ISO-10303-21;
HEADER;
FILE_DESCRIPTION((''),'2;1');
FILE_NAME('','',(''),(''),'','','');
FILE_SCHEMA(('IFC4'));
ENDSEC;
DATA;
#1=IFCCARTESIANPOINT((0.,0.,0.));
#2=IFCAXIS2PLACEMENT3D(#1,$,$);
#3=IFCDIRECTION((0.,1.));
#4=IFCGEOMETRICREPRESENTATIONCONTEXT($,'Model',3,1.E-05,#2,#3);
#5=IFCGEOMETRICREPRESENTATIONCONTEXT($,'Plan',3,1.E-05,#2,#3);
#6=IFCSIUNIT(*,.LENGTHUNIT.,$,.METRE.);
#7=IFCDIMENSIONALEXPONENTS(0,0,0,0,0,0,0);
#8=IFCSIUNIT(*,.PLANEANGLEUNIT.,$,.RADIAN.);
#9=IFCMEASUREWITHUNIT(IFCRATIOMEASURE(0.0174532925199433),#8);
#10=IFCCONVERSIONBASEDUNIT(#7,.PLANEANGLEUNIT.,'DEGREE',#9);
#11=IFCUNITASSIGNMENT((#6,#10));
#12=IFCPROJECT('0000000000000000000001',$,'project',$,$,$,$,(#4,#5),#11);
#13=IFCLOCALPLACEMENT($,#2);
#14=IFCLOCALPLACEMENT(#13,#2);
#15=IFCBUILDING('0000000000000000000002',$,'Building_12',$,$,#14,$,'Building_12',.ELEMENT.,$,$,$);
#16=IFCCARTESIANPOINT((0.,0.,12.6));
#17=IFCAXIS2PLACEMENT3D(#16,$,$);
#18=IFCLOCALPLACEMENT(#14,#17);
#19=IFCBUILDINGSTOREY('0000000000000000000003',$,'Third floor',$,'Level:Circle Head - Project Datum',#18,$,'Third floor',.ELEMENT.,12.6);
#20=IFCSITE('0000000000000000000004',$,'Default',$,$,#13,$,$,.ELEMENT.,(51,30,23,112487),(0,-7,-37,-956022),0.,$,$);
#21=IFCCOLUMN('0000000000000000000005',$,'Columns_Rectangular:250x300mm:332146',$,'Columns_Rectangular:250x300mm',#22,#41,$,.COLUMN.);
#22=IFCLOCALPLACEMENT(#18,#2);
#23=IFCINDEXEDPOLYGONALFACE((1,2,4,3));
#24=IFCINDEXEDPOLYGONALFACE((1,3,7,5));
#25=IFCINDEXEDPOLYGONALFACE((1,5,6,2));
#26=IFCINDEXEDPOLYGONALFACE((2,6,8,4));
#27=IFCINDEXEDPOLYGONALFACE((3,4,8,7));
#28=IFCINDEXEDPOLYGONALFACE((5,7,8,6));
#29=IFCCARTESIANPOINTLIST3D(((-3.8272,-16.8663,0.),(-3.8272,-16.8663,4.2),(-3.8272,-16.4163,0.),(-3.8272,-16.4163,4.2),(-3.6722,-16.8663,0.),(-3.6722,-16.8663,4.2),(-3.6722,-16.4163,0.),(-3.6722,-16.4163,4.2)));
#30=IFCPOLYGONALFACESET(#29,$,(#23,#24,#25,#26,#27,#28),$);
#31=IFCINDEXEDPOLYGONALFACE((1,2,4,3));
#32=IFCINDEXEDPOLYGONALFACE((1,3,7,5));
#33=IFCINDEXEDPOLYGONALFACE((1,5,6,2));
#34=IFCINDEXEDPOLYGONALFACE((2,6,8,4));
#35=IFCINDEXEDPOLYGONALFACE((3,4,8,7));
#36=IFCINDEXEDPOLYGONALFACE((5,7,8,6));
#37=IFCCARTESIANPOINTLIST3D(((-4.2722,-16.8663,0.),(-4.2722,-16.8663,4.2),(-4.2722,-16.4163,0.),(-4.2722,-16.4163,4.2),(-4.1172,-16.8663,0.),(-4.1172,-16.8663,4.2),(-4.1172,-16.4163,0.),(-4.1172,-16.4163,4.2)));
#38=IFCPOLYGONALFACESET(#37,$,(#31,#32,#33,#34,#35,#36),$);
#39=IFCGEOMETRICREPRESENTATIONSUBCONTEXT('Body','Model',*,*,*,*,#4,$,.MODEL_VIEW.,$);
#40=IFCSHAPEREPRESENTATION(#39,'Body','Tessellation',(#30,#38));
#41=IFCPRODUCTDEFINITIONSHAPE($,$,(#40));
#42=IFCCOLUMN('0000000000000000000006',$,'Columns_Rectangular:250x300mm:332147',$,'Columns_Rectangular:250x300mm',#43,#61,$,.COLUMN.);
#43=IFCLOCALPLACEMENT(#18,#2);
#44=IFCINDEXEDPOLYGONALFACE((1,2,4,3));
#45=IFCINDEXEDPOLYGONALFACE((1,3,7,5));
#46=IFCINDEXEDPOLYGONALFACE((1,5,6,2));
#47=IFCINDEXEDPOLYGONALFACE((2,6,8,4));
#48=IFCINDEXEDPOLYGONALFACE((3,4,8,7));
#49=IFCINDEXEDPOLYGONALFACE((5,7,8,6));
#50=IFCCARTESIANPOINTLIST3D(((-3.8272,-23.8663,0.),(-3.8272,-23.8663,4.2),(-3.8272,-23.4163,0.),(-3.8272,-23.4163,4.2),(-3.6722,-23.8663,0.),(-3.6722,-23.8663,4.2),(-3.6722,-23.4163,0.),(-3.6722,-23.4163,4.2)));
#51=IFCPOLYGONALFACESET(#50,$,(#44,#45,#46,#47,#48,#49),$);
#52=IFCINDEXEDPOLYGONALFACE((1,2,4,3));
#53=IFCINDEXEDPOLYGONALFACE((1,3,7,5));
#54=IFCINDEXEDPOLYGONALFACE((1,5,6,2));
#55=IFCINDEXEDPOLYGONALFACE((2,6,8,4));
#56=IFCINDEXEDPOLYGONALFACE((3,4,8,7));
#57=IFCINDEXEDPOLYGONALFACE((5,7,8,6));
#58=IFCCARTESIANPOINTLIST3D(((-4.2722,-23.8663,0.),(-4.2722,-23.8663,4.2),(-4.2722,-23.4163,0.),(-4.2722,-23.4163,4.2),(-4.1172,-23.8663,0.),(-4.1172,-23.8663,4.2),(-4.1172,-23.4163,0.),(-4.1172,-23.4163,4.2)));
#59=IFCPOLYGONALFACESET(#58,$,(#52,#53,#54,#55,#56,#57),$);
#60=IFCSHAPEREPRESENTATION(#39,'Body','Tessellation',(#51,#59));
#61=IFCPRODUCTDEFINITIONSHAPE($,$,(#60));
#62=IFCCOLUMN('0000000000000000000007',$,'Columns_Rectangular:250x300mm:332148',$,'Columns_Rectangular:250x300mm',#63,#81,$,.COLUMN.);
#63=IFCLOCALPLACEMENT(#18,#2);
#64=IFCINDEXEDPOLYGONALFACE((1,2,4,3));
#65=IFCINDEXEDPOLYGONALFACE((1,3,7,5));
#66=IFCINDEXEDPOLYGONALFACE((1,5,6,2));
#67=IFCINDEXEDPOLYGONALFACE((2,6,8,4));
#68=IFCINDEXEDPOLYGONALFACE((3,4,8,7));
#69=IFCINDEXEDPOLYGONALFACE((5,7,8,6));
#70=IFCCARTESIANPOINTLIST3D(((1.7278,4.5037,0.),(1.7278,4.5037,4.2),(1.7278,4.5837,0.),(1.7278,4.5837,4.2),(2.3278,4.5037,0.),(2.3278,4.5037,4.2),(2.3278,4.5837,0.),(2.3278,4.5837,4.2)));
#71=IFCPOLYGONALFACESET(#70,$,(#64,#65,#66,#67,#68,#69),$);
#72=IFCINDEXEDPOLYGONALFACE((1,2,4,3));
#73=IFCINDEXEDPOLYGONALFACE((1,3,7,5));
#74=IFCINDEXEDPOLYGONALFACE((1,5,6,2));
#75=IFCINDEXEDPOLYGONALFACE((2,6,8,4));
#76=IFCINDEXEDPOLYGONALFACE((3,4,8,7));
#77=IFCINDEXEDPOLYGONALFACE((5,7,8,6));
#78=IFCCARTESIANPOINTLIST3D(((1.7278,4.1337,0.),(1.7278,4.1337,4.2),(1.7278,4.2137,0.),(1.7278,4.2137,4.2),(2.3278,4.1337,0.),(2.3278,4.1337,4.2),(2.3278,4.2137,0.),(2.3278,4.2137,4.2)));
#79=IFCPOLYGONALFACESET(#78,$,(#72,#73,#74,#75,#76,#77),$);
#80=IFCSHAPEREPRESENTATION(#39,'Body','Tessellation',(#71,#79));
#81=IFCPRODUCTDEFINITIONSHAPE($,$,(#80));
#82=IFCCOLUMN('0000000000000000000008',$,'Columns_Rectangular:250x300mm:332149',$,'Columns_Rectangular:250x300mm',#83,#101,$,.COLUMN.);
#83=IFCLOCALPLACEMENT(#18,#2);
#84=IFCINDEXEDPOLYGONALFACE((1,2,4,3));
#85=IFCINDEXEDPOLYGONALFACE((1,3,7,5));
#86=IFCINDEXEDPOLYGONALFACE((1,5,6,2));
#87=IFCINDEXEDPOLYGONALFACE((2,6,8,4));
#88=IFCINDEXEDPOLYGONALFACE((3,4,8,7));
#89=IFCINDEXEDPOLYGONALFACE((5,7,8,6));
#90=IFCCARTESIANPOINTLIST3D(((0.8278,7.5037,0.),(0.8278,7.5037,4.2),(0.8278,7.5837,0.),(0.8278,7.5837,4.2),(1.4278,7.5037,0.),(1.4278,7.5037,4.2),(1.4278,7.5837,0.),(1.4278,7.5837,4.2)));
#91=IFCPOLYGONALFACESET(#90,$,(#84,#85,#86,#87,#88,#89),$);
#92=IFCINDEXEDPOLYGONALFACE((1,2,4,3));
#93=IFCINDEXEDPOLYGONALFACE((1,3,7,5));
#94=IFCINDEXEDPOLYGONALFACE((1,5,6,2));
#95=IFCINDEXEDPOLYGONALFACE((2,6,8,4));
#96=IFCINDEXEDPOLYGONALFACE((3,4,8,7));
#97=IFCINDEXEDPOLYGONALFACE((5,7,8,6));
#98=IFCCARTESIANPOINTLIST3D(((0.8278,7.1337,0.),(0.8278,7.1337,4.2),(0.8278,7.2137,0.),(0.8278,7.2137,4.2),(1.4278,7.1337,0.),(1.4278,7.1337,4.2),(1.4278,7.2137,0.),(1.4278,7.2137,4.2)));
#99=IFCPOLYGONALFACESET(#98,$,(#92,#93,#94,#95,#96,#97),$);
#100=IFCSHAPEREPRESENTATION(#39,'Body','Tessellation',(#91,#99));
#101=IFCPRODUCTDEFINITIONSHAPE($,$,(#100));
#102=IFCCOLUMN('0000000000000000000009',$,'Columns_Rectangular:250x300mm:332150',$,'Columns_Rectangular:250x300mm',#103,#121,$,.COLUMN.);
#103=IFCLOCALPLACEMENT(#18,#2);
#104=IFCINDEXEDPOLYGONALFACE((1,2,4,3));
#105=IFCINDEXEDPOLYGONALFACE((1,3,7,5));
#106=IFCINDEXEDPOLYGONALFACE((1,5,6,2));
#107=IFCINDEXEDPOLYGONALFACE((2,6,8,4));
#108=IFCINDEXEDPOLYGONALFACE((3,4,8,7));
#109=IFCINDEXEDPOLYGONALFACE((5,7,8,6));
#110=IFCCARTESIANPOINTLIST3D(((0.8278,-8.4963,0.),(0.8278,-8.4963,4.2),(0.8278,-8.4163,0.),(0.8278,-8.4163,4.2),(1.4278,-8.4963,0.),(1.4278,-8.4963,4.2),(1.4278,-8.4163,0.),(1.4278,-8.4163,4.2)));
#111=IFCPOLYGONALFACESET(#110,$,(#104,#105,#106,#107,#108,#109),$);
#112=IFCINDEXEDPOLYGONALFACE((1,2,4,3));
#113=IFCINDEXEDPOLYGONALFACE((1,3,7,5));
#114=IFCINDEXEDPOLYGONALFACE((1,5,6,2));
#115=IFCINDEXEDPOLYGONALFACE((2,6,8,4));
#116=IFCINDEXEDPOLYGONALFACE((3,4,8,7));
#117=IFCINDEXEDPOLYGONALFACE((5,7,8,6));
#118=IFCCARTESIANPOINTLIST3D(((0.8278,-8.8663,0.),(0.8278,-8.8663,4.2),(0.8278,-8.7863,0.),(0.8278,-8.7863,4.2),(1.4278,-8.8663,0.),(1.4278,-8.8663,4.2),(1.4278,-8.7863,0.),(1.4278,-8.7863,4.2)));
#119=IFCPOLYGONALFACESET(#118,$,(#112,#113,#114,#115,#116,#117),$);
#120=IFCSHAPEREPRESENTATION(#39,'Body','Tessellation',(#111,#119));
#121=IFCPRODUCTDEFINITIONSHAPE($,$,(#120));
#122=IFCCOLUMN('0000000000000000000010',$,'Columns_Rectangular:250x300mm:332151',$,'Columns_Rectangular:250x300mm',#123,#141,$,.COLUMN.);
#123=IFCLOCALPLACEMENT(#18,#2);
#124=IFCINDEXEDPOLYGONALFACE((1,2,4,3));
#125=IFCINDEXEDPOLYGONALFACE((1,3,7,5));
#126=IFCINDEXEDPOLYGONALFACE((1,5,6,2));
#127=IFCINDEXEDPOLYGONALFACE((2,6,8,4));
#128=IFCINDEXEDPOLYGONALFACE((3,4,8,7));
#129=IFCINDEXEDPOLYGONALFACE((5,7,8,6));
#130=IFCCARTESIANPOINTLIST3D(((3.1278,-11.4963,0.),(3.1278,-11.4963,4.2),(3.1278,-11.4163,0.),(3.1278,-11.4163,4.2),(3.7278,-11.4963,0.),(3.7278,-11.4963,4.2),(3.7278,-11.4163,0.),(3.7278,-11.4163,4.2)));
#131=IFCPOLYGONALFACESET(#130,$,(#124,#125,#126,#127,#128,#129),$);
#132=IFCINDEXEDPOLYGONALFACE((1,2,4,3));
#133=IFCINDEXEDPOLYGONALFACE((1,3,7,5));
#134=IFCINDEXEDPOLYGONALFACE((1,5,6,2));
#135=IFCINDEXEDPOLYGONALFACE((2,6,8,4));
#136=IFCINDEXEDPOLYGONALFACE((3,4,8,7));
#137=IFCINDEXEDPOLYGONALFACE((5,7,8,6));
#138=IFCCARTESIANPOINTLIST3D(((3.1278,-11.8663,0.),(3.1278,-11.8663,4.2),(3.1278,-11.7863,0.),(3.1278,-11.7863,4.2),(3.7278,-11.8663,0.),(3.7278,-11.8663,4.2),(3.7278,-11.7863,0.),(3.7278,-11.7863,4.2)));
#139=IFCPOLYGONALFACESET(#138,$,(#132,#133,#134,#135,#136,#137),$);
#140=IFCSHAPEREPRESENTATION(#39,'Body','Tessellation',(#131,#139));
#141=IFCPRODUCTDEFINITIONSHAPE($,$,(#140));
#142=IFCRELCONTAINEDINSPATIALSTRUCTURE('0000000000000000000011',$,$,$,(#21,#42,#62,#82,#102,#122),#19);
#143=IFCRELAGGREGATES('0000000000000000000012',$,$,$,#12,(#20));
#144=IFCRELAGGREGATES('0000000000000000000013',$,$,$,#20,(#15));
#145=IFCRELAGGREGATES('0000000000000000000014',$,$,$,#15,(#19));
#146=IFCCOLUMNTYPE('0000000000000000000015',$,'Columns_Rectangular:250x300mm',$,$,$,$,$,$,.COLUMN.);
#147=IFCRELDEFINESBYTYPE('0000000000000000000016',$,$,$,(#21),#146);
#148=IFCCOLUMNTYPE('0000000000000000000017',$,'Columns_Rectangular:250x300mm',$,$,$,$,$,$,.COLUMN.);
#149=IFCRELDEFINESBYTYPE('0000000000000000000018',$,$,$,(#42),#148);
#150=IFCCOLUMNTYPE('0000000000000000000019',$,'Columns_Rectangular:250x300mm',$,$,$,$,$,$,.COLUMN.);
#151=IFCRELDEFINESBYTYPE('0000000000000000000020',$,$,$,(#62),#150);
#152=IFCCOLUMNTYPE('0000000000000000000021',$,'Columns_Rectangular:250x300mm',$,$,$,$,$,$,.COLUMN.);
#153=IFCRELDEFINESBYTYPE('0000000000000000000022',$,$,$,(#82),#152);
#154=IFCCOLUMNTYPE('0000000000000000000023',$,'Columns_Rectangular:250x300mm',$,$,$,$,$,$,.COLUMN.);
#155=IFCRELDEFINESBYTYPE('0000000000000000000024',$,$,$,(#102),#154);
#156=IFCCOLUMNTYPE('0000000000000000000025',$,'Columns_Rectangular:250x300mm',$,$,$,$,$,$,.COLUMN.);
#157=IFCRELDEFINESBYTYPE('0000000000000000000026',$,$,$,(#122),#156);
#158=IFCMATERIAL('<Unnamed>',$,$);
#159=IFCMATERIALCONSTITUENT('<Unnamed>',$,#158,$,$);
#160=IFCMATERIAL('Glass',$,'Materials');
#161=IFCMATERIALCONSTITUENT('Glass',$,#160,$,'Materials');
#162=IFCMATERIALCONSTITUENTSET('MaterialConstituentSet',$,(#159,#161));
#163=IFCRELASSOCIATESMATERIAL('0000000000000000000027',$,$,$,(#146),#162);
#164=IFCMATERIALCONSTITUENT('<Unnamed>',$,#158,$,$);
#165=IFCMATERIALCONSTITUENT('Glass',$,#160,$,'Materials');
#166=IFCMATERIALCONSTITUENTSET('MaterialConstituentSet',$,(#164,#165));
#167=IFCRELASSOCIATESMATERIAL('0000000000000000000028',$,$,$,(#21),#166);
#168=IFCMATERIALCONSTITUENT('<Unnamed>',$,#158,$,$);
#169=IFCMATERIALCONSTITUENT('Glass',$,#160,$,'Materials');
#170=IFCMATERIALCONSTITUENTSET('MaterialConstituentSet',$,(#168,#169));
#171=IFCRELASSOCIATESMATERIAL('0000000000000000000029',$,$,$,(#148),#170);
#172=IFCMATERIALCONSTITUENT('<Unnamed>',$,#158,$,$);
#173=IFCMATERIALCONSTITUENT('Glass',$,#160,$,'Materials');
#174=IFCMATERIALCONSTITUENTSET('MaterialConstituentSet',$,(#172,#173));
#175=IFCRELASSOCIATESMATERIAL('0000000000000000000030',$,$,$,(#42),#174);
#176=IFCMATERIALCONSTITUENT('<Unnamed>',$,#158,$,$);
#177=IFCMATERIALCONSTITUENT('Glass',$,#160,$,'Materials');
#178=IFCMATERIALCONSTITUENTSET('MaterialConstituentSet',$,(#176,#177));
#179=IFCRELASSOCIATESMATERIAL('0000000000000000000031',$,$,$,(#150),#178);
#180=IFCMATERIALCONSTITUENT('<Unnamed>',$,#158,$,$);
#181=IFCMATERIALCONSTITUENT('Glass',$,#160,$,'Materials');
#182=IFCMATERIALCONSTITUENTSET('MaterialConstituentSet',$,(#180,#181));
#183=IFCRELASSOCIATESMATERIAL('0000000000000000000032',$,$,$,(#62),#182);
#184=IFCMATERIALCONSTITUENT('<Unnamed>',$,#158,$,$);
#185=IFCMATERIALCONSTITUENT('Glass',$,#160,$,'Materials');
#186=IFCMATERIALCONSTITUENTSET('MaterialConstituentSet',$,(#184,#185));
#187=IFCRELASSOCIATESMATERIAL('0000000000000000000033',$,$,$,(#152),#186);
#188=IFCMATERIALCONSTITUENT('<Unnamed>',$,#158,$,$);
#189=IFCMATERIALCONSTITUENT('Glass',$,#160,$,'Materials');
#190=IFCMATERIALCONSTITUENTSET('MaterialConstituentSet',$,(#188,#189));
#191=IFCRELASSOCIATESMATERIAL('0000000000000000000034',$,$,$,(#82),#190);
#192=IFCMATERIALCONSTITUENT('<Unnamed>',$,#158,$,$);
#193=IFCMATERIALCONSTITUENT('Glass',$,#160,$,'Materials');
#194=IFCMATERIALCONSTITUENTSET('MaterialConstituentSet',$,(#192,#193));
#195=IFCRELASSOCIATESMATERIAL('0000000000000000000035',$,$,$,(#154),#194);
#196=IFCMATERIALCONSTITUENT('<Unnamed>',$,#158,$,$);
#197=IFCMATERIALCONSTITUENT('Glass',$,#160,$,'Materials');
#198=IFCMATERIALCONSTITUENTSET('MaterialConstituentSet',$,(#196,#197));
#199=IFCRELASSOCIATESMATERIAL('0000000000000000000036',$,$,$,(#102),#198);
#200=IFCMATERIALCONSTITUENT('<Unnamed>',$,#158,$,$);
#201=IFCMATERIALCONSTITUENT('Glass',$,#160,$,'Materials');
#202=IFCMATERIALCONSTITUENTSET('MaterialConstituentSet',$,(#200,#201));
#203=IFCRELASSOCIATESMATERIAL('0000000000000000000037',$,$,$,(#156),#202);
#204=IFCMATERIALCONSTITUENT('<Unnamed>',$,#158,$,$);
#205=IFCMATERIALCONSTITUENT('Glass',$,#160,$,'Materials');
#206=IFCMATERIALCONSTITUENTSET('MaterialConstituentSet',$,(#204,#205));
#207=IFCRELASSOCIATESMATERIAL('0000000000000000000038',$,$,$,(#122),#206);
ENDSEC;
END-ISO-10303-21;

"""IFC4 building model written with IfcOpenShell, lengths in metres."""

from ifc_helpers import new_model, entity, si_unit, converted_unit, direction, frame, origin, place, context, subcontext, project, spatial, indexed_curve, outline, extrude, source, transform, mapped, material, constituent, constituent_set, type_object, type_shapes, element, save


model = new_model("IFC4")

# Units and contexts
model_context = context("Model", 3, precision=1e-05, world=origin(), true_north=direction((0.0, 1.0)))
plan_context = context("Plan", 3, precision=1e-05, world=origin(), true_north=direction((0.0, 1.0)))
body_context = subcontext(model_context, "Body", "Model", "MODEL_VIEW")
ifc_project = project(units=[si_unit("LENGTHUNIT", "METRE"), converted_unit("PLANEANGLEUNIT", "DEGREE", entity("IfcRatioMeasure", 0.0174532925199433), si_unit("PLANEANGLEUNIT", "RADIAN"), dimensions=[0, 0, 0, 0, 0, 0, 0])], contexts=[model_context, plan_context])

# Site, building, storey
site_placement = place(None, origin())
site = spatial("IfcSite", under=ifc_project, at=site_placement, Name="Default", CompositionType="ELEMENT", RefLatitude=(51, 30, 23, 112487), RefLongitude=(0, -7, -37, -956022), RefElevation=0.0)
building_placement = place(site_placement, origin())
building = spatial("IfcBuilding", under=site, at=building_placement, Name="Building_12", LongName="Building_12", CompositionType="ELEMENT")
storey_placement = place(building_placement, frame((0.0, 0.0, 12.6)))
storey = spatial("IfcBuildingStorey", under=building, at=storey_placement, Name="Third floor", ObjectType="Level:Circle Head - Project Datum", LongName="Third floor", CompositionType="ELEMENT", Elevation=12.6)

# Columns
ifc_material_1 = material(Name="<Unnamed>")
ifc_constituent_1 = constituent(ifc_material_1, Name="<Unnamed>")
ifc_material_2 = material(Name="Glass", Category="Materials")
ifc_constituent_2 = constituent(ifc_material_2, Name="Glass", Category="Materials")
ifc_constituent_set_1 = constituent_set(constituents=[ifc_constituent_1, ifc_constituent_2], Name="MaterialConstituentSet")
ifc_constituent_3 = constituent(ifc_material_1, Name="<Unnamed>")
ifc_constituent_4 = constituent(ifc_material_2, Name="Glass", Category="Materials")
ifc_constituent_set_2 = constituent_set(constituents=[ifc_constituent_3, ifc_constituent_4], Name="MaterialConstituentSet")
column_type_1 = type_object("IfcColumnType", Name="Columns_Rectangular:250x300mm", PredefinedType="COLUMN", material=ifc_constituent_set_2)
shared_shape_1 = source(origin(), body_context, "Body", "SweptSolid", [
    extrude(outline(indexed_curve([(-0.225, -0.0775), (0.225, -0.0775), (0.225, 0.0775), (-0.225, 0.0775), (-0.225, -0.0775)], self_intersect=False)), frame((-3.7497, -16.6413, 12.6), z_axis=(0.0, 0.0, 1.0), x_axis=(0.0, -1.0, 0.0)), (0.0, 0.0, 1.0), 4.2),
    extrude(outline(indexed_curve([(-0.225, -0.0775), (0.225, -0.0775), (0.225, 0.0775), (-0.225, 0.0775), (-0.225, -0.0775)], self_intersect=False)), frame((-4.1947, -16.6413, 12.6), z_axis=(0.0, 0.0, 1.0), x_axis=(0.0, -1.0, 0.0)), (0.0, 0.0, 1.0), 4.2),
])
type_shapes(column_type_1, [shared_shape_1])
column_1_placement = place(storey_placement, frame((0.0, 0.0, -12.6)))
element("IfcColumn", 1, at=column_1_placement, inside=storey, type_object=column_type_1, material=ifc_constituent_set_1, Name="Columns_Rectangular:250x300mm:332146", ObjectType="Columns_Rectangular:250x300mm", PredefinedType="COLUMN", context=body_context, shape_type="MappedRepresentation", body=[
    mapped(shared_shape_1, transform((0.0, 0.0, 0.0), scale=1.0)),
])
ifc_constituent_5 = constituent(ifc_material_1, Name="<Unnamed>")
ifc_constituent_6 = constituent(ifc_material_2, Name="Glass", Category="Materials")
ifc_constituent_set_3 = constituent_set(constituents=[ifc_constituent_5, ifc_constituent_6], Name="MaterialConstituentSet")
ifc_constituent_7 = constituent(ifc_material_1, Name="<Unnamed>")
ifc_constituent_8 = constituent(ifc_material_2, Name="Glass", Category="Materials")
ifc_constituent_set_4 = constituent_set(constituents=[ifc_constituent_7, ifc_constituent_8], Name="MaterialConstituentSet")
column_type_2 = type_object("IfcColumnType", Name="Columns_Rectangular:250x300mm", PredefinedType="COLUMN", material=ifc_constituent_set_4)
shared_shape_2 = source(origin(), body_context, "Body", "SweptSolid", [
    extrude(outline(indexed_curve([(-0.225, -0.0775), (0.225, -0.0775), (0.225, 0.0775), (-0.225, 0.0775), (-0.225, -0.0775)], self_intersect=False)), frame((-3.7497, -23.6413, 12.6), z_axis=(0.0, 0.0, 1.0), x_axis=(0.0, -1.0, 0.0)), (0.0, 0.0, 1.0), 4.2),
    extrude(outline(indexed_curve([(-0.225, -0.0775), (0.225, -0.0775), (0.225, 0.0775), (-0.225, 0.0775), (-0.225, -0.0775)], self_intersect=False)), frame((-4.1947, -23.6413, 12.6), z_axis=(0.0, 0.0, 1.0), x_axis=(0.0, -1.0, 0.0)), (0.0, 0.0, 1.0), 4.2),
])
type_shapes(column_type_2, [shared_shape_2])
column_2_placement = place(storey_placement, frame((0.0, 0.0, -12.6)))
element("IfcColumn", 2, at=column_2_placement, inside=storey, type_object=column_type_2, material=ifc_constituent_set_3, Name="Columns_Rectangular:250x300mm:332147", ObjectType="Columns_Rectangular:250x300mm", PredefinedType="COLUMN", context=body_context, shape_type="MappedRepresentation", body=[
    mapped(shared_shape_2, transform((0.0, 0.0, 0.0), scale=1.0)),
])
ifc_constituent_9 = constituent(ifc_material_1, Name="<Unnamed>")
ifc_constituent_10 = constituent(ifc_material_2, Name="Glass", Category="Materials")
ifc_constituent_set_5 = constituent_set(constituents=[ifc_constituent_9, ifc_constituent_10], Name="MaterialConstituentSet")
ifc_constituent_11 = constituent(ifc_material_1, Name="<Unnamed>")
ifc_constituent_12 = constituent(ifc_material_2, Name="Glass", Category="Materials")
ifc_constituent_set_6 = constituent_set(constituents=[ifc_constituent_11, ifc_constituent_12], Name="MaterialConstituentSet")
column_type_3 = type_object("IfcColumnType", Name="Columns_Rectangular:250x300mm", PredefinedType="COLUMN", material=ifc_constituent_set_6)
shared_shape_3 = source(origin(), body_context, "Body", "SweptSolid", [
    extrude(outline(indexed_curve([(-0.04, -0.3), (0.04, -0.3), (0.04, 0.3), (-0.04, 0.3), (-0.04, -0.3)], self_intersect=False)), frame((2.0278, 4.5437, 12.6), z_axis=(0.0, 0.0, 1.0), x_axis=(0.0, -1.0, 0.0)), (0.0, 0.0, 1.0), 4.2),
    extrude(outline(indexed_curve([(-0.04, -0.3), (0.04, -0.3), (0.04, 0.3), (-0.04, 0.3), (-0.04, -0.3)], self_intersect=False)), frame((2.0278, 4.1737, 12.6), z_axis=(0.0, 0.0, 1.0), x_axis=(0.0, -1.0, 0.0)), (0.0, 0.0, 1.0), 4.2),
])
type_shapes(column_type_3, [shared_shape_3])
column_3_placement = place(storey_placement, frame((0.0, 0.0, -12.6)))
element("IfcColumn", 3, at=column_3_placement, inside=storey, type_object=column_type_3, material=ifc_constituent_set_5, Name="Columns_Rectangular:250x300mm:332148", ObjectType="Columns_Rectangular:250x300mm", PredefinedType="COLUMN", context=body_context, shape_type="MappedRepresentation", body=[
    mapped(shared_shape_3, transform((0.0, 0.0, 0.0), scale=1.0)),
])
ifc_constituent_13 = constituent(ifc_material_1, Name="<Unnamed>")
ifc_constituent_14 = constituent(ifc_material_2, Name="Glass", Category="Materials")
ifc_constituent_set_7 = constituent_set(constituents=[ifc_constituent_13, ifc_constituent_14], Name="MaterialConstituentSet")
ifc_constituent_15 = constituent(ifc_material_1, Name="<Unnamed>")
ifc_constituent_16 = constituent(ifc_material_2, Name="Glass", Category="Materials")
ifc_constituent_set_8 = constituent_set(constituents=[ifc_constituent_15, ifc_constituent_16], Name="MaterialConstituentSet")
column_type_4 = type_object("IfcColumnType", Name="Columns_Rectangular:250x300mm", PredefinedType="COLUMN", material=ifc_constituent_set_8)
shared_shape_4 = source(origin(), body_context, "Body", "SweptSolid", [
    extrude(outline(indexed_curve([(-0.04, -0.3), (0.04, -0.3), (0.04, 0.3), (-0.04, 0.3), (-0.04, -0.3)], self_intersect=False)), frame((1.1278, 7.5437, 12.6), z_axis=(0.0, 0.0, 1.0), x_axis=(0.0, -1.0, 0.0)), (0.0, 0.0, 1.0), 4.2),
    extrude(outline(indexed_curve([(-0.04, -0.3), (0.04, -0.3), (0.04, 0.3), (-0.04, 0.3), (-0.04, -0.3)], self_intersect=False)), frame((1.1278, 7.1737, 12.6), z_axis=(0.0, 0.0, 1.0), x_axis=(0.0, -1.0, 0.0)), (0.0, 0.0, 1.0), 4.2),
])
type_shapes(column_type_4, [shared_shape_4])
column_4_placement = place(storey_placement, frame((0.0, 0.0, -12.6)))
element("IfcColumn", 4, at=column_4_placement, inside=storey, type_object=column_type_4, material=ifc_constituent_set_7, Name="Columns_Rectangular:250x300mm:332149", ObjectType="Columns_Rectangular:250x300mm", PredefinedType="COLUMN", context=body_context, shape_type="MappedRepresentation", body=[
    mapped(shared_shape_4, transform((0.0, 0.0, 0.0), scale=1.0)),
])
ifc_constituent_17 = constituent(ifc_material_1, Name="<Unnamed>")
ifc_constituent_18 = constituent(ifc_material_2, Name="Glass", Category="Materials")
ifc_constituent_set_9 = constituent_set(constituents=[ifc_constituent_17, ifc_constituent_18], Name="MaterialConstituentSet")
ifc_constituent_19 = constituent(ifc_material_1, Name="<Unnamed>")
ifc_constituent_20 = constituent(ifc_material_2, Name="Glass", Category="Materials")
ifc_constituent_set_10 = constituent_set(constituents=[ifc_constituent_19, ifc_constituent_20], Name="MaterialConstituentSet")
column_type_5 = type_object("IfcColumnType", Name="Columns_Rectangular:250x300mm", PredefinedType="COLUMN", material=ifc_constituent_set_10)
shared_shape_5 = source(origin(), body_context, "Body", "SweptSolid", [
    extrude(outline(indexed_curve([(-0.04, -0.3), (0.04, -0.3), (0.04, 0.3), (-0.04, 0.3), (-0.04, -0.3)], self_intersect=False)), frame((1.1278, -8.4563, 12.6), z_axis=(0.0, 0.0, 1.0), x_axis=(0.0, -1.0, 0.0)), (0.0, 0.0, 1.0), 4.2),
    extrude(outline(indexed_curve([(-0.04, -0.3), (0.04, -0.3), (0.04, 0.3), (-0.04, 0.3), (-0.04, -0.3)], self_intersect=False)), frame((1.1278, -8.8263, 12.6), z_axis=(0.0, 0.0, 1.0), x_axis=(0.0, -1.0, 0.0)), (0.0, 0.0, 1.0), 4.2),
])
type_shapes(column_type_5, [shared_shape_5])
column_5_placement = place(storey_placement, frame((0.0, 0.0, -12.6)))
element("IfcColumn", 5, at=column_5_placement, inside=storey, type_object=column_type_5, material=ifc_constituent_set_9, Name="Columns_Rectangular:250x300mm:332150", ObjectType="Columns_Rectangular:250x300mm", PredefinedType="COLUMN", context=body_context, shape_type="MappedRepresentation", body=[
    mapped(shared_shape_5, transform((0.0, 0.0, 0.0), scale=1.0)),
])
ifc_constituent_21 = constituent(ifc_material_1, Name="<Unnamed>")
ifc_constituent_22 = constituent(ifc_material_2, Name="Glass", Category="Materials")
ifc_constituent_set_11 = constituent_set(constituents=[ifc_constituent_21, ifc_constituent_22], Name="MaterialConstituentSet")
ifc_constituent_23 = constituent(ifc_material_1, Name="<Unnamed>")
ifc_constituent_24 = constituent(ifc_material_2, Name="Glass", Category="Materials")
ifc_constituent_set_12 = constituent_set(constituents=[ifc_constituent_23, ifc_constituent_24], Name="MaterialConstituentSet")
column_type_6 = type_object("IfcColumnType", Name="Columns_Rectangular:250x300mm", PredefinedType="COLUMN", material=ifc_constituent_set_12)
shared_shape_6 = source(origin(), body_context, "Body", "SweptSolid", [
    extrude(outline(indexed_curve([(-0.04, -0.3), (0.04, -0.3), (0.04, 0.3), (-0.04, 0.3), (-0.04, -0.3)], self_intersect=False)), frame((3.4278, -11.4563, 12.6), z_axis=(0.0, 0.0, 1.0), x_axis=(0.0, -1.0, 0.0)), (0.0, 0.0, 1.0), 4.2),
    extrude(outline(indexed_curve([(-0.04, -0.3), (0.04, -0.3), (0.04, 0.3), (-0.04, 0.3), (-0.04, -0.3)], self_intersect=False)), frame((3.4278, -11.8263, 12.6), z_axis=(0.0, 0.0, 1.0), x_axis=(0.0, -1.0, 0.0)), (0.0, 0.0, 1.0), 4.2),
])
type_shapes(column_type_6, [shared_shape_6])
column_6_placement = place(storey_placement, frame((0.0, 0.0, -12.6)))
element("IfcColumn", 6, at=column_6_placement, inside=storey, type_object=column_type_6, material=ifc_constituent_set_11, Name="Columns_Rectangular:250x300mm:332151", ObjectType="Columns_Rectangular:250x300mm", PredefinedType="COLUMN", context=body_context, shape_type="MappedRepresentation", body=[
    mapped(shared_shape_6, transform((0.0, 0.0, 0.0), scale=1.0)),
])

save(model, "model.ifc")
